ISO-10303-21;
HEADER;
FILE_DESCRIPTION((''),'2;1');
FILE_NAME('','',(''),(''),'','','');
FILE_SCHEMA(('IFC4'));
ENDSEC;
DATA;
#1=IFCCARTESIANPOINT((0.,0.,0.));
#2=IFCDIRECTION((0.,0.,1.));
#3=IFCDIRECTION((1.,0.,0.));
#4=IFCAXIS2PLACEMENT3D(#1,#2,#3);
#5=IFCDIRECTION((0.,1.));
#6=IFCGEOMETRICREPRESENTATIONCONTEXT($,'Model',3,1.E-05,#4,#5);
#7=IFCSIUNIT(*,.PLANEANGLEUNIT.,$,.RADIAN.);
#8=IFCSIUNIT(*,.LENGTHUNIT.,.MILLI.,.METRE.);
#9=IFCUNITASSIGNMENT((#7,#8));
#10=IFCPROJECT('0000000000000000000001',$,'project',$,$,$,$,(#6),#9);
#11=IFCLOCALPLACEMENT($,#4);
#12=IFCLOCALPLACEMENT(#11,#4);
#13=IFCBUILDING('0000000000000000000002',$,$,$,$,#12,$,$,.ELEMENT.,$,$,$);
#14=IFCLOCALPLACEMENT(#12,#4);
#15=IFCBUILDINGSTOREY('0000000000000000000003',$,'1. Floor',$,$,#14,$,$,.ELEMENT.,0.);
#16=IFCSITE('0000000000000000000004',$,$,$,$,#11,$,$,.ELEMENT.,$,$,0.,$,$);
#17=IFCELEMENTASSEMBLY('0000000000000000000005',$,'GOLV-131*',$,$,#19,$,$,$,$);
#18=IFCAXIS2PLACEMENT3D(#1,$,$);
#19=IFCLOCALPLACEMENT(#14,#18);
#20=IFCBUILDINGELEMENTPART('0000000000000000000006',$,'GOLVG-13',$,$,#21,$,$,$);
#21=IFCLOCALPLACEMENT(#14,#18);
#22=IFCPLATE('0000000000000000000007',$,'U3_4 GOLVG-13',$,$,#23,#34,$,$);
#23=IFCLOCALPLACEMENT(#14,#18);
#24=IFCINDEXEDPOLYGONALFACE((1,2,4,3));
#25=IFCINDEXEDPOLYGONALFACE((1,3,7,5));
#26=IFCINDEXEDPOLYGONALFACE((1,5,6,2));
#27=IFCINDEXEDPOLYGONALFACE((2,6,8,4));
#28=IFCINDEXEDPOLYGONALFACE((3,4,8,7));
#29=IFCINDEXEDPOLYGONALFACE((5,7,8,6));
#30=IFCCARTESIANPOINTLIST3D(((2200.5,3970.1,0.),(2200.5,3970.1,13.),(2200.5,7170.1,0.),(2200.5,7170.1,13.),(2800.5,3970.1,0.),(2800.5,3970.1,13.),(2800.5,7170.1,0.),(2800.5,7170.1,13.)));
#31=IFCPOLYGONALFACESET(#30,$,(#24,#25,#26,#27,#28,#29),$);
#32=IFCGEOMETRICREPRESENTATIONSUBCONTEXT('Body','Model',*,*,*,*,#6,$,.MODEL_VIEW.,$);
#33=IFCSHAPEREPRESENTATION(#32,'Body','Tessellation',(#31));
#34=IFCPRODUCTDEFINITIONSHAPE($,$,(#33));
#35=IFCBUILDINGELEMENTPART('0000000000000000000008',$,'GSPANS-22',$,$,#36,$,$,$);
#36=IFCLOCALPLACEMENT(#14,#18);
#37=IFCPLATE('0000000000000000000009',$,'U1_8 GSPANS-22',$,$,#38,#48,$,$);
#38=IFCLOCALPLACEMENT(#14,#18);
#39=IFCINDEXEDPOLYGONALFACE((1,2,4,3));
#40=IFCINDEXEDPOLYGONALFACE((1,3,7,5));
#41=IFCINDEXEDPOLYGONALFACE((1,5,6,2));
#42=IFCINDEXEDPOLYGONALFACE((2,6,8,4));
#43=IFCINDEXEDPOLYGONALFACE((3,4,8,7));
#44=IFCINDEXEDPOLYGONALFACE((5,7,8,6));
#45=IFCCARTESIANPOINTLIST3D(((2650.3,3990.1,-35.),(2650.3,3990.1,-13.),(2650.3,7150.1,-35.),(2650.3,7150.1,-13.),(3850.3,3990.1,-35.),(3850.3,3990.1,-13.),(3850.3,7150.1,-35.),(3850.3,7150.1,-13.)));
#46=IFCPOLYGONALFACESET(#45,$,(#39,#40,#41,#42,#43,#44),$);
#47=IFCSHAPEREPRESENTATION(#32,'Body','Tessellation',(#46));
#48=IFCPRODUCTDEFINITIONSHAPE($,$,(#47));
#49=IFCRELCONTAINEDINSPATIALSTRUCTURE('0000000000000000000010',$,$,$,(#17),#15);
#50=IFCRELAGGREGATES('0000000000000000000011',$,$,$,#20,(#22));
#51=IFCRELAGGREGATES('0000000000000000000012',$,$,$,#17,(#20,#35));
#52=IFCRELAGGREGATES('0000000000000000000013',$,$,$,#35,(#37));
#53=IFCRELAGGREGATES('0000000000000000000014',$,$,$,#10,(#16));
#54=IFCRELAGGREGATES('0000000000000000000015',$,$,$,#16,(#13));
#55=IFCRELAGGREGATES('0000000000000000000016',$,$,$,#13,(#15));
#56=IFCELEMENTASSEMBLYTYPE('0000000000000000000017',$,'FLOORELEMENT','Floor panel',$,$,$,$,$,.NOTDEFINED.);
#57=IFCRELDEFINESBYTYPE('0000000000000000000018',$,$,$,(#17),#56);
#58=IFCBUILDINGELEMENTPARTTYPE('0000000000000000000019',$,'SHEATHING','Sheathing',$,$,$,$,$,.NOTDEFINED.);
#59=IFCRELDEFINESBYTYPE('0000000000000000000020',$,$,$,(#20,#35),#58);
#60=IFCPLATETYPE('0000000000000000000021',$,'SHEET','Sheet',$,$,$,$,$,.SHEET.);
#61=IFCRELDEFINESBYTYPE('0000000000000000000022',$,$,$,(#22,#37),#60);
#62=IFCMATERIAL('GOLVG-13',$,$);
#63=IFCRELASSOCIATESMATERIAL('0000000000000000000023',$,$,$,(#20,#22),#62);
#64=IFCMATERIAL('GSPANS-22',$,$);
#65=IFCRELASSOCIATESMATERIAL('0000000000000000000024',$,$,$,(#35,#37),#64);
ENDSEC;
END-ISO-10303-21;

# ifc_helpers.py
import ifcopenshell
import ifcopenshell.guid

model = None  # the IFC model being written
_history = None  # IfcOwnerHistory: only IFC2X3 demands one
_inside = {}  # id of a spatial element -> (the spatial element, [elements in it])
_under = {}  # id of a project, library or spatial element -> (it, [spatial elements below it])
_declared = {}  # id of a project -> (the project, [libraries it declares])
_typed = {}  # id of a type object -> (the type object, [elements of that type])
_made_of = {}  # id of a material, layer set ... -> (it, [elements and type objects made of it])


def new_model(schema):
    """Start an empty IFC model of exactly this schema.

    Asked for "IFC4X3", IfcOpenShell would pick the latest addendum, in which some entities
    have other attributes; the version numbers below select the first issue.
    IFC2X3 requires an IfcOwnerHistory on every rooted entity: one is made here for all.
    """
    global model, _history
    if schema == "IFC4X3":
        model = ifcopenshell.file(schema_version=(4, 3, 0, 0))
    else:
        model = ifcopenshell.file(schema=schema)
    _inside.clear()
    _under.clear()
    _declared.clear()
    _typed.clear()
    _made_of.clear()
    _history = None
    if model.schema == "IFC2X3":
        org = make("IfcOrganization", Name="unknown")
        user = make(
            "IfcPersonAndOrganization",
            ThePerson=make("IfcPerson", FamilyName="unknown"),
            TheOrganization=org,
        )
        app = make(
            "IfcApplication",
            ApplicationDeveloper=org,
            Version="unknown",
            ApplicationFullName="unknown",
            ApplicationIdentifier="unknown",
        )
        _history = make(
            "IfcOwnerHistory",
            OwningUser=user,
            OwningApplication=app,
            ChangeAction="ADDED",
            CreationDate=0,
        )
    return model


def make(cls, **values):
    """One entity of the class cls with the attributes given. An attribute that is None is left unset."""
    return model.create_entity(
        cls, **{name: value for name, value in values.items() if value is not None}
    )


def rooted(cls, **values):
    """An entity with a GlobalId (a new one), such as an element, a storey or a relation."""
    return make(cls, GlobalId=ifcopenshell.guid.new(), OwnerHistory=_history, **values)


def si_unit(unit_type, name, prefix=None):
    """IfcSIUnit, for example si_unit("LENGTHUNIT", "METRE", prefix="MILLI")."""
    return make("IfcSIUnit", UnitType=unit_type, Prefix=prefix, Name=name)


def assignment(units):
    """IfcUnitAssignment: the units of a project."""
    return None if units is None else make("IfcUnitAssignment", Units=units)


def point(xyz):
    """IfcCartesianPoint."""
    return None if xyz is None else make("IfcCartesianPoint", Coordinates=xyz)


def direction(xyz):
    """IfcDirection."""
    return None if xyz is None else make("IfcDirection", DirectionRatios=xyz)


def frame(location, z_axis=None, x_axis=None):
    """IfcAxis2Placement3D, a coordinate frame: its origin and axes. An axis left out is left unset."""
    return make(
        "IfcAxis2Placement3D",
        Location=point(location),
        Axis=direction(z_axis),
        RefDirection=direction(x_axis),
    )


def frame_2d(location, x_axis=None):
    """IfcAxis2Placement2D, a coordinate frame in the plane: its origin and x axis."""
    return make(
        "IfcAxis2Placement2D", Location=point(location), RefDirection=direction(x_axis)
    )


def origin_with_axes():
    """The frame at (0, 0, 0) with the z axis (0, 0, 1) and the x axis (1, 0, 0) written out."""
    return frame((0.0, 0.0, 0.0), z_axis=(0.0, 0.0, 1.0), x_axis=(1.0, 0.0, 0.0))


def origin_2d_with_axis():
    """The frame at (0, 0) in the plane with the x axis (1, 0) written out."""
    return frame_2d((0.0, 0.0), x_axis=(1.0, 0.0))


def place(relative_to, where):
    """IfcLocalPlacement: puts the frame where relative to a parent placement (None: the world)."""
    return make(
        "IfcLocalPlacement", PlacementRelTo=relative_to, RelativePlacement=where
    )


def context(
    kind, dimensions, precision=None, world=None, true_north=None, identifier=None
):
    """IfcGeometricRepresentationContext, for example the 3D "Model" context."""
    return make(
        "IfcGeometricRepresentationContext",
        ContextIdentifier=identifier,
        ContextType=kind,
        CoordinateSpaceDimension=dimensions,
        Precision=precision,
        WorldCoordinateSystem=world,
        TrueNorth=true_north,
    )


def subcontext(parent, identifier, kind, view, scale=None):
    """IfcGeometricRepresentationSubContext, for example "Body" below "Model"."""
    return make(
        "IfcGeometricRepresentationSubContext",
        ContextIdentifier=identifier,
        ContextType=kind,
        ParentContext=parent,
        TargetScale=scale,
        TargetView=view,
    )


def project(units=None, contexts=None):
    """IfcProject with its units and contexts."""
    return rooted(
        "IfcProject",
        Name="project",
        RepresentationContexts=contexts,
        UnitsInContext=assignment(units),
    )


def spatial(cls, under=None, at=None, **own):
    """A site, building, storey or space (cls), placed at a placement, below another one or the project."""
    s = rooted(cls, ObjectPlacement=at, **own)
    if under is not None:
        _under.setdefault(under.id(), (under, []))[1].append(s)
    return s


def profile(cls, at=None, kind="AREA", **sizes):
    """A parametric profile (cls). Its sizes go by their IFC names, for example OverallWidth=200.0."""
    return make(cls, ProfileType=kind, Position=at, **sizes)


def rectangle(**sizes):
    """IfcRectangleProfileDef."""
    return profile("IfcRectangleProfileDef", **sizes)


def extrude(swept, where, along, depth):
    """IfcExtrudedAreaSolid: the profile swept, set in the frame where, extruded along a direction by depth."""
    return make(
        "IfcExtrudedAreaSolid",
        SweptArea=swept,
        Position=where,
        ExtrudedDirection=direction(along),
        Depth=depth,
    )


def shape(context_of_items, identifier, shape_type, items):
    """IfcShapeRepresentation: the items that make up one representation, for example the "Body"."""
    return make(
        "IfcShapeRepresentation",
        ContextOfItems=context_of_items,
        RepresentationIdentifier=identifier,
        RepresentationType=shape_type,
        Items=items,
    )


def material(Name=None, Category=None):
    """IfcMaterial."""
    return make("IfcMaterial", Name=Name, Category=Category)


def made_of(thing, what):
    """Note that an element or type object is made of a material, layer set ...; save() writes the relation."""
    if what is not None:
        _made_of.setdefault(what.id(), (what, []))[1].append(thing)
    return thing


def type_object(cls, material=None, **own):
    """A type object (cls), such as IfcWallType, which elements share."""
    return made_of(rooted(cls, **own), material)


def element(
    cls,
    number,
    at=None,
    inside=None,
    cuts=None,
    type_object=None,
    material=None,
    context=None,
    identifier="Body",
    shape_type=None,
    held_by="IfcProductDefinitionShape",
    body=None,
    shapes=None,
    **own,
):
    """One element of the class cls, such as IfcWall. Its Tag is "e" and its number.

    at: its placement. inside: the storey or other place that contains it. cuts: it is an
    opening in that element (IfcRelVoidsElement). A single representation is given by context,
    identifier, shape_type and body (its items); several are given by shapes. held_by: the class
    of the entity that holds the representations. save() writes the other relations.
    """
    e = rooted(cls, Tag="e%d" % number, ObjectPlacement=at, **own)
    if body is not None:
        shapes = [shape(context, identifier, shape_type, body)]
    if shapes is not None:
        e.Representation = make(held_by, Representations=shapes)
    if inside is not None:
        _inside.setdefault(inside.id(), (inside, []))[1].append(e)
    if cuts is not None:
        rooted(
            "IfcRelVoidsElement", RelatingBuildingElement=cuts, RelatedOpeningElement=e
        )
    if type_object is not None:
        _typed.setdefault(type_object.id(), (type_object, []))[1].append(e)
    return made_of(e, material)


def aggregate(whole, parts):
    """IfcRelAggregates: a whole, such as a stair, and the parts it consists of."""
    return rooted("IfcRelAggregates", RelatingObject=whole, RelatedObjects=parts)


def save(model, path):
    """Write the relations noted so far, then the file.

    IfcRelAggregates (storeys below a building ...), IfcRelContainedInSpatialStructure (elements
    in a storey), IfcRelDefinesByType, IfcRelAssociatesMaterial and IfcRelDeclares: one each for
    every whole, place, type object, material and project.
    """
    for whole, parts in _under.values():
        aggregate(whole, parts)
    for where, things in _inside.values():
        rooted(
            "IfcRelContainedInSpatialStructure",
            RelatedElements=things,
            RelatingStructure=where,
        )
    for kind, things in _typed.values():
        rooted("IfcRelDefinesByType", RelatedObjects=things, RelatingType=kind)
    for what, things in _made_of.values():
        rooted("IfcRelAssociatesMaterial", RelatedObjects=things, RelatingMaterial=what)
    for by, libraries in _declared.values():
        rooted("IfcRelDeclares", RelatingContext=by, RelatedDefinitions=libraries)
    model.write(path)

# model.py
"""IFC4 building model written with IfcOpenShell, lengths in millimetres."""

from ifc_helpers import new_model, si_unit, direction, frame, origin_with_axes, origin_2d_with_axis, place, context, subcontext, project, spatial, rectangle, extrude, material, type_object, element, aggregate, save


model = new_model("IFC4")

# Units and contexts
model_context = context("Model", 3, precision=1e-05, world=origin_with_axes(), true_north=direction((0.0, 1.0)))
body_context = subcontext(model_context, "Body", "Model", "MODEL_VIEW")
ifc_project = project(units=[si_unit("PLANEANGLEUNIT", "RADIAN"), si_unit("LENGTHUNIT", "METRE", prefix="MILLI")], contexts=[model_context])

# Site, building, storey
site_placement = place(None, origin_with_axes())
site = spatial("IfcSite", under=ifc_project, at=site_placement, CompositionType="ELEMENT", RefElevation=0.0)
building_placement = place(site_placement, origin_with_axes())
building = spatial("IfcBuilding", under=site, at=building_placement, CompositionType="ELEMENT")
storey_placement = place(building_placement, origin_with_axes())
storey = spatial("IfcBuildingStorey", under=building, at=storey_placement, Name="1. Floor", CompositionType="ELEMENT", Elevation=0.0)

# Element assembly
element_assembly_type_1 = type_object("IfcElementAssemblyType", Name="FLOORELEMENT", Description="Floor panel", PredefinedType="NOTDEFINED")
assembly_1_placement = place(storey_placement, origin_with_axes())
assembly_1 = element("IfcElementAssembly", 1, at=assembly_1_placement, inside=storey, type_object=element_assembly_type_1, Name="GOLV-131*")

# Building element part, plate
ifc_material_1 = material(Name="GOLVG-13")
building_element_part_type_1 = type_object("IfcBuildingElementPartType", Name="SHEATHING", Description="Sheathing", PredefinedType="NOTDEFINED")
building_element_part_1_placement = place(storey_placement, origin_with_axes())
building_element_part_1 = element("IfcBuildingElementPart", 2, at=building_element_part_1_placement, type_object=building_element_part_type_1, material=ifc_material_1, Name="GOLVG-13")
plate_type_1 = type_object("IfcPlateType", Name="SHEET", Description="Sheet", PredefinedType="SHEET")
plate_1_placement = place(storey_placement, frame((2500.5, 5970.1, 13.0), z_axis=(0.0, 0.0, 1.0), x_axis=(1.0, 0.0, 0.0)))
plate_1 = element("IfcPlate", 3, at=plate_1_placement, type_object=plate_type_1, material=ifc_material_1, Name="U3_4 GOLVG-13", context=body_context, shape_type="SweptSolid", body=[
    extrude(rectangle(XDim=13.0, YDim=600.0, at=origin_2d_with_axis()), frame((0.0, -2000.0, -6.5), z_axis=(0.0, 1.0, 0.0), x_axis=(0.0, 0.0, 1.0)), (0.0, 0.0, 1.0), 3200.0),
])
aggregate(building_element_part_1, [plate_1])

# Building element part
ifc_material_2 = material(Name="GSPANS-22")
building_element_part_2_placement = place(storey_placement, origin_with_axes())
building_element_part_2 = element("IfcBuildingElementPart", 4, at=building_element_part_2_placement, type_object=building_element_part_type_1, material=ifc_material_2, Name="GSPANS-22")
aggregate(assembly_1, [building_element_part_1, building_element_part_2])

# Plate
plate_2_placement = place(storey_placement, frame((3250.3, 5150.1, -13.0), z_axis=(0.0, 0.0, 1.0), x_axis=(1.0, 0.0, 0.0)))
plate_2 = element("IfcPlate", 5, at=plate_2_placement, type_object=plate_type_1, material=ifc_material_2, Name="U1_8 GSPANS-22", context=body_context, shape_type="SweptSolid", body=[
    extrude(rectangle(XDim=22.0, YDim=1200.0, at=origin_2d_with_axis()), frame((0.0, -1160.0, -11.0), z_axis=(0.0, 1.0, 0.0), x_axis=(0.0, 0.0, 1.0)), (0.0, 0.0, 1.0), 3160.0),
])
aggregate(building_element_part_2, [plate_2])

save(model, "model.ifc")
